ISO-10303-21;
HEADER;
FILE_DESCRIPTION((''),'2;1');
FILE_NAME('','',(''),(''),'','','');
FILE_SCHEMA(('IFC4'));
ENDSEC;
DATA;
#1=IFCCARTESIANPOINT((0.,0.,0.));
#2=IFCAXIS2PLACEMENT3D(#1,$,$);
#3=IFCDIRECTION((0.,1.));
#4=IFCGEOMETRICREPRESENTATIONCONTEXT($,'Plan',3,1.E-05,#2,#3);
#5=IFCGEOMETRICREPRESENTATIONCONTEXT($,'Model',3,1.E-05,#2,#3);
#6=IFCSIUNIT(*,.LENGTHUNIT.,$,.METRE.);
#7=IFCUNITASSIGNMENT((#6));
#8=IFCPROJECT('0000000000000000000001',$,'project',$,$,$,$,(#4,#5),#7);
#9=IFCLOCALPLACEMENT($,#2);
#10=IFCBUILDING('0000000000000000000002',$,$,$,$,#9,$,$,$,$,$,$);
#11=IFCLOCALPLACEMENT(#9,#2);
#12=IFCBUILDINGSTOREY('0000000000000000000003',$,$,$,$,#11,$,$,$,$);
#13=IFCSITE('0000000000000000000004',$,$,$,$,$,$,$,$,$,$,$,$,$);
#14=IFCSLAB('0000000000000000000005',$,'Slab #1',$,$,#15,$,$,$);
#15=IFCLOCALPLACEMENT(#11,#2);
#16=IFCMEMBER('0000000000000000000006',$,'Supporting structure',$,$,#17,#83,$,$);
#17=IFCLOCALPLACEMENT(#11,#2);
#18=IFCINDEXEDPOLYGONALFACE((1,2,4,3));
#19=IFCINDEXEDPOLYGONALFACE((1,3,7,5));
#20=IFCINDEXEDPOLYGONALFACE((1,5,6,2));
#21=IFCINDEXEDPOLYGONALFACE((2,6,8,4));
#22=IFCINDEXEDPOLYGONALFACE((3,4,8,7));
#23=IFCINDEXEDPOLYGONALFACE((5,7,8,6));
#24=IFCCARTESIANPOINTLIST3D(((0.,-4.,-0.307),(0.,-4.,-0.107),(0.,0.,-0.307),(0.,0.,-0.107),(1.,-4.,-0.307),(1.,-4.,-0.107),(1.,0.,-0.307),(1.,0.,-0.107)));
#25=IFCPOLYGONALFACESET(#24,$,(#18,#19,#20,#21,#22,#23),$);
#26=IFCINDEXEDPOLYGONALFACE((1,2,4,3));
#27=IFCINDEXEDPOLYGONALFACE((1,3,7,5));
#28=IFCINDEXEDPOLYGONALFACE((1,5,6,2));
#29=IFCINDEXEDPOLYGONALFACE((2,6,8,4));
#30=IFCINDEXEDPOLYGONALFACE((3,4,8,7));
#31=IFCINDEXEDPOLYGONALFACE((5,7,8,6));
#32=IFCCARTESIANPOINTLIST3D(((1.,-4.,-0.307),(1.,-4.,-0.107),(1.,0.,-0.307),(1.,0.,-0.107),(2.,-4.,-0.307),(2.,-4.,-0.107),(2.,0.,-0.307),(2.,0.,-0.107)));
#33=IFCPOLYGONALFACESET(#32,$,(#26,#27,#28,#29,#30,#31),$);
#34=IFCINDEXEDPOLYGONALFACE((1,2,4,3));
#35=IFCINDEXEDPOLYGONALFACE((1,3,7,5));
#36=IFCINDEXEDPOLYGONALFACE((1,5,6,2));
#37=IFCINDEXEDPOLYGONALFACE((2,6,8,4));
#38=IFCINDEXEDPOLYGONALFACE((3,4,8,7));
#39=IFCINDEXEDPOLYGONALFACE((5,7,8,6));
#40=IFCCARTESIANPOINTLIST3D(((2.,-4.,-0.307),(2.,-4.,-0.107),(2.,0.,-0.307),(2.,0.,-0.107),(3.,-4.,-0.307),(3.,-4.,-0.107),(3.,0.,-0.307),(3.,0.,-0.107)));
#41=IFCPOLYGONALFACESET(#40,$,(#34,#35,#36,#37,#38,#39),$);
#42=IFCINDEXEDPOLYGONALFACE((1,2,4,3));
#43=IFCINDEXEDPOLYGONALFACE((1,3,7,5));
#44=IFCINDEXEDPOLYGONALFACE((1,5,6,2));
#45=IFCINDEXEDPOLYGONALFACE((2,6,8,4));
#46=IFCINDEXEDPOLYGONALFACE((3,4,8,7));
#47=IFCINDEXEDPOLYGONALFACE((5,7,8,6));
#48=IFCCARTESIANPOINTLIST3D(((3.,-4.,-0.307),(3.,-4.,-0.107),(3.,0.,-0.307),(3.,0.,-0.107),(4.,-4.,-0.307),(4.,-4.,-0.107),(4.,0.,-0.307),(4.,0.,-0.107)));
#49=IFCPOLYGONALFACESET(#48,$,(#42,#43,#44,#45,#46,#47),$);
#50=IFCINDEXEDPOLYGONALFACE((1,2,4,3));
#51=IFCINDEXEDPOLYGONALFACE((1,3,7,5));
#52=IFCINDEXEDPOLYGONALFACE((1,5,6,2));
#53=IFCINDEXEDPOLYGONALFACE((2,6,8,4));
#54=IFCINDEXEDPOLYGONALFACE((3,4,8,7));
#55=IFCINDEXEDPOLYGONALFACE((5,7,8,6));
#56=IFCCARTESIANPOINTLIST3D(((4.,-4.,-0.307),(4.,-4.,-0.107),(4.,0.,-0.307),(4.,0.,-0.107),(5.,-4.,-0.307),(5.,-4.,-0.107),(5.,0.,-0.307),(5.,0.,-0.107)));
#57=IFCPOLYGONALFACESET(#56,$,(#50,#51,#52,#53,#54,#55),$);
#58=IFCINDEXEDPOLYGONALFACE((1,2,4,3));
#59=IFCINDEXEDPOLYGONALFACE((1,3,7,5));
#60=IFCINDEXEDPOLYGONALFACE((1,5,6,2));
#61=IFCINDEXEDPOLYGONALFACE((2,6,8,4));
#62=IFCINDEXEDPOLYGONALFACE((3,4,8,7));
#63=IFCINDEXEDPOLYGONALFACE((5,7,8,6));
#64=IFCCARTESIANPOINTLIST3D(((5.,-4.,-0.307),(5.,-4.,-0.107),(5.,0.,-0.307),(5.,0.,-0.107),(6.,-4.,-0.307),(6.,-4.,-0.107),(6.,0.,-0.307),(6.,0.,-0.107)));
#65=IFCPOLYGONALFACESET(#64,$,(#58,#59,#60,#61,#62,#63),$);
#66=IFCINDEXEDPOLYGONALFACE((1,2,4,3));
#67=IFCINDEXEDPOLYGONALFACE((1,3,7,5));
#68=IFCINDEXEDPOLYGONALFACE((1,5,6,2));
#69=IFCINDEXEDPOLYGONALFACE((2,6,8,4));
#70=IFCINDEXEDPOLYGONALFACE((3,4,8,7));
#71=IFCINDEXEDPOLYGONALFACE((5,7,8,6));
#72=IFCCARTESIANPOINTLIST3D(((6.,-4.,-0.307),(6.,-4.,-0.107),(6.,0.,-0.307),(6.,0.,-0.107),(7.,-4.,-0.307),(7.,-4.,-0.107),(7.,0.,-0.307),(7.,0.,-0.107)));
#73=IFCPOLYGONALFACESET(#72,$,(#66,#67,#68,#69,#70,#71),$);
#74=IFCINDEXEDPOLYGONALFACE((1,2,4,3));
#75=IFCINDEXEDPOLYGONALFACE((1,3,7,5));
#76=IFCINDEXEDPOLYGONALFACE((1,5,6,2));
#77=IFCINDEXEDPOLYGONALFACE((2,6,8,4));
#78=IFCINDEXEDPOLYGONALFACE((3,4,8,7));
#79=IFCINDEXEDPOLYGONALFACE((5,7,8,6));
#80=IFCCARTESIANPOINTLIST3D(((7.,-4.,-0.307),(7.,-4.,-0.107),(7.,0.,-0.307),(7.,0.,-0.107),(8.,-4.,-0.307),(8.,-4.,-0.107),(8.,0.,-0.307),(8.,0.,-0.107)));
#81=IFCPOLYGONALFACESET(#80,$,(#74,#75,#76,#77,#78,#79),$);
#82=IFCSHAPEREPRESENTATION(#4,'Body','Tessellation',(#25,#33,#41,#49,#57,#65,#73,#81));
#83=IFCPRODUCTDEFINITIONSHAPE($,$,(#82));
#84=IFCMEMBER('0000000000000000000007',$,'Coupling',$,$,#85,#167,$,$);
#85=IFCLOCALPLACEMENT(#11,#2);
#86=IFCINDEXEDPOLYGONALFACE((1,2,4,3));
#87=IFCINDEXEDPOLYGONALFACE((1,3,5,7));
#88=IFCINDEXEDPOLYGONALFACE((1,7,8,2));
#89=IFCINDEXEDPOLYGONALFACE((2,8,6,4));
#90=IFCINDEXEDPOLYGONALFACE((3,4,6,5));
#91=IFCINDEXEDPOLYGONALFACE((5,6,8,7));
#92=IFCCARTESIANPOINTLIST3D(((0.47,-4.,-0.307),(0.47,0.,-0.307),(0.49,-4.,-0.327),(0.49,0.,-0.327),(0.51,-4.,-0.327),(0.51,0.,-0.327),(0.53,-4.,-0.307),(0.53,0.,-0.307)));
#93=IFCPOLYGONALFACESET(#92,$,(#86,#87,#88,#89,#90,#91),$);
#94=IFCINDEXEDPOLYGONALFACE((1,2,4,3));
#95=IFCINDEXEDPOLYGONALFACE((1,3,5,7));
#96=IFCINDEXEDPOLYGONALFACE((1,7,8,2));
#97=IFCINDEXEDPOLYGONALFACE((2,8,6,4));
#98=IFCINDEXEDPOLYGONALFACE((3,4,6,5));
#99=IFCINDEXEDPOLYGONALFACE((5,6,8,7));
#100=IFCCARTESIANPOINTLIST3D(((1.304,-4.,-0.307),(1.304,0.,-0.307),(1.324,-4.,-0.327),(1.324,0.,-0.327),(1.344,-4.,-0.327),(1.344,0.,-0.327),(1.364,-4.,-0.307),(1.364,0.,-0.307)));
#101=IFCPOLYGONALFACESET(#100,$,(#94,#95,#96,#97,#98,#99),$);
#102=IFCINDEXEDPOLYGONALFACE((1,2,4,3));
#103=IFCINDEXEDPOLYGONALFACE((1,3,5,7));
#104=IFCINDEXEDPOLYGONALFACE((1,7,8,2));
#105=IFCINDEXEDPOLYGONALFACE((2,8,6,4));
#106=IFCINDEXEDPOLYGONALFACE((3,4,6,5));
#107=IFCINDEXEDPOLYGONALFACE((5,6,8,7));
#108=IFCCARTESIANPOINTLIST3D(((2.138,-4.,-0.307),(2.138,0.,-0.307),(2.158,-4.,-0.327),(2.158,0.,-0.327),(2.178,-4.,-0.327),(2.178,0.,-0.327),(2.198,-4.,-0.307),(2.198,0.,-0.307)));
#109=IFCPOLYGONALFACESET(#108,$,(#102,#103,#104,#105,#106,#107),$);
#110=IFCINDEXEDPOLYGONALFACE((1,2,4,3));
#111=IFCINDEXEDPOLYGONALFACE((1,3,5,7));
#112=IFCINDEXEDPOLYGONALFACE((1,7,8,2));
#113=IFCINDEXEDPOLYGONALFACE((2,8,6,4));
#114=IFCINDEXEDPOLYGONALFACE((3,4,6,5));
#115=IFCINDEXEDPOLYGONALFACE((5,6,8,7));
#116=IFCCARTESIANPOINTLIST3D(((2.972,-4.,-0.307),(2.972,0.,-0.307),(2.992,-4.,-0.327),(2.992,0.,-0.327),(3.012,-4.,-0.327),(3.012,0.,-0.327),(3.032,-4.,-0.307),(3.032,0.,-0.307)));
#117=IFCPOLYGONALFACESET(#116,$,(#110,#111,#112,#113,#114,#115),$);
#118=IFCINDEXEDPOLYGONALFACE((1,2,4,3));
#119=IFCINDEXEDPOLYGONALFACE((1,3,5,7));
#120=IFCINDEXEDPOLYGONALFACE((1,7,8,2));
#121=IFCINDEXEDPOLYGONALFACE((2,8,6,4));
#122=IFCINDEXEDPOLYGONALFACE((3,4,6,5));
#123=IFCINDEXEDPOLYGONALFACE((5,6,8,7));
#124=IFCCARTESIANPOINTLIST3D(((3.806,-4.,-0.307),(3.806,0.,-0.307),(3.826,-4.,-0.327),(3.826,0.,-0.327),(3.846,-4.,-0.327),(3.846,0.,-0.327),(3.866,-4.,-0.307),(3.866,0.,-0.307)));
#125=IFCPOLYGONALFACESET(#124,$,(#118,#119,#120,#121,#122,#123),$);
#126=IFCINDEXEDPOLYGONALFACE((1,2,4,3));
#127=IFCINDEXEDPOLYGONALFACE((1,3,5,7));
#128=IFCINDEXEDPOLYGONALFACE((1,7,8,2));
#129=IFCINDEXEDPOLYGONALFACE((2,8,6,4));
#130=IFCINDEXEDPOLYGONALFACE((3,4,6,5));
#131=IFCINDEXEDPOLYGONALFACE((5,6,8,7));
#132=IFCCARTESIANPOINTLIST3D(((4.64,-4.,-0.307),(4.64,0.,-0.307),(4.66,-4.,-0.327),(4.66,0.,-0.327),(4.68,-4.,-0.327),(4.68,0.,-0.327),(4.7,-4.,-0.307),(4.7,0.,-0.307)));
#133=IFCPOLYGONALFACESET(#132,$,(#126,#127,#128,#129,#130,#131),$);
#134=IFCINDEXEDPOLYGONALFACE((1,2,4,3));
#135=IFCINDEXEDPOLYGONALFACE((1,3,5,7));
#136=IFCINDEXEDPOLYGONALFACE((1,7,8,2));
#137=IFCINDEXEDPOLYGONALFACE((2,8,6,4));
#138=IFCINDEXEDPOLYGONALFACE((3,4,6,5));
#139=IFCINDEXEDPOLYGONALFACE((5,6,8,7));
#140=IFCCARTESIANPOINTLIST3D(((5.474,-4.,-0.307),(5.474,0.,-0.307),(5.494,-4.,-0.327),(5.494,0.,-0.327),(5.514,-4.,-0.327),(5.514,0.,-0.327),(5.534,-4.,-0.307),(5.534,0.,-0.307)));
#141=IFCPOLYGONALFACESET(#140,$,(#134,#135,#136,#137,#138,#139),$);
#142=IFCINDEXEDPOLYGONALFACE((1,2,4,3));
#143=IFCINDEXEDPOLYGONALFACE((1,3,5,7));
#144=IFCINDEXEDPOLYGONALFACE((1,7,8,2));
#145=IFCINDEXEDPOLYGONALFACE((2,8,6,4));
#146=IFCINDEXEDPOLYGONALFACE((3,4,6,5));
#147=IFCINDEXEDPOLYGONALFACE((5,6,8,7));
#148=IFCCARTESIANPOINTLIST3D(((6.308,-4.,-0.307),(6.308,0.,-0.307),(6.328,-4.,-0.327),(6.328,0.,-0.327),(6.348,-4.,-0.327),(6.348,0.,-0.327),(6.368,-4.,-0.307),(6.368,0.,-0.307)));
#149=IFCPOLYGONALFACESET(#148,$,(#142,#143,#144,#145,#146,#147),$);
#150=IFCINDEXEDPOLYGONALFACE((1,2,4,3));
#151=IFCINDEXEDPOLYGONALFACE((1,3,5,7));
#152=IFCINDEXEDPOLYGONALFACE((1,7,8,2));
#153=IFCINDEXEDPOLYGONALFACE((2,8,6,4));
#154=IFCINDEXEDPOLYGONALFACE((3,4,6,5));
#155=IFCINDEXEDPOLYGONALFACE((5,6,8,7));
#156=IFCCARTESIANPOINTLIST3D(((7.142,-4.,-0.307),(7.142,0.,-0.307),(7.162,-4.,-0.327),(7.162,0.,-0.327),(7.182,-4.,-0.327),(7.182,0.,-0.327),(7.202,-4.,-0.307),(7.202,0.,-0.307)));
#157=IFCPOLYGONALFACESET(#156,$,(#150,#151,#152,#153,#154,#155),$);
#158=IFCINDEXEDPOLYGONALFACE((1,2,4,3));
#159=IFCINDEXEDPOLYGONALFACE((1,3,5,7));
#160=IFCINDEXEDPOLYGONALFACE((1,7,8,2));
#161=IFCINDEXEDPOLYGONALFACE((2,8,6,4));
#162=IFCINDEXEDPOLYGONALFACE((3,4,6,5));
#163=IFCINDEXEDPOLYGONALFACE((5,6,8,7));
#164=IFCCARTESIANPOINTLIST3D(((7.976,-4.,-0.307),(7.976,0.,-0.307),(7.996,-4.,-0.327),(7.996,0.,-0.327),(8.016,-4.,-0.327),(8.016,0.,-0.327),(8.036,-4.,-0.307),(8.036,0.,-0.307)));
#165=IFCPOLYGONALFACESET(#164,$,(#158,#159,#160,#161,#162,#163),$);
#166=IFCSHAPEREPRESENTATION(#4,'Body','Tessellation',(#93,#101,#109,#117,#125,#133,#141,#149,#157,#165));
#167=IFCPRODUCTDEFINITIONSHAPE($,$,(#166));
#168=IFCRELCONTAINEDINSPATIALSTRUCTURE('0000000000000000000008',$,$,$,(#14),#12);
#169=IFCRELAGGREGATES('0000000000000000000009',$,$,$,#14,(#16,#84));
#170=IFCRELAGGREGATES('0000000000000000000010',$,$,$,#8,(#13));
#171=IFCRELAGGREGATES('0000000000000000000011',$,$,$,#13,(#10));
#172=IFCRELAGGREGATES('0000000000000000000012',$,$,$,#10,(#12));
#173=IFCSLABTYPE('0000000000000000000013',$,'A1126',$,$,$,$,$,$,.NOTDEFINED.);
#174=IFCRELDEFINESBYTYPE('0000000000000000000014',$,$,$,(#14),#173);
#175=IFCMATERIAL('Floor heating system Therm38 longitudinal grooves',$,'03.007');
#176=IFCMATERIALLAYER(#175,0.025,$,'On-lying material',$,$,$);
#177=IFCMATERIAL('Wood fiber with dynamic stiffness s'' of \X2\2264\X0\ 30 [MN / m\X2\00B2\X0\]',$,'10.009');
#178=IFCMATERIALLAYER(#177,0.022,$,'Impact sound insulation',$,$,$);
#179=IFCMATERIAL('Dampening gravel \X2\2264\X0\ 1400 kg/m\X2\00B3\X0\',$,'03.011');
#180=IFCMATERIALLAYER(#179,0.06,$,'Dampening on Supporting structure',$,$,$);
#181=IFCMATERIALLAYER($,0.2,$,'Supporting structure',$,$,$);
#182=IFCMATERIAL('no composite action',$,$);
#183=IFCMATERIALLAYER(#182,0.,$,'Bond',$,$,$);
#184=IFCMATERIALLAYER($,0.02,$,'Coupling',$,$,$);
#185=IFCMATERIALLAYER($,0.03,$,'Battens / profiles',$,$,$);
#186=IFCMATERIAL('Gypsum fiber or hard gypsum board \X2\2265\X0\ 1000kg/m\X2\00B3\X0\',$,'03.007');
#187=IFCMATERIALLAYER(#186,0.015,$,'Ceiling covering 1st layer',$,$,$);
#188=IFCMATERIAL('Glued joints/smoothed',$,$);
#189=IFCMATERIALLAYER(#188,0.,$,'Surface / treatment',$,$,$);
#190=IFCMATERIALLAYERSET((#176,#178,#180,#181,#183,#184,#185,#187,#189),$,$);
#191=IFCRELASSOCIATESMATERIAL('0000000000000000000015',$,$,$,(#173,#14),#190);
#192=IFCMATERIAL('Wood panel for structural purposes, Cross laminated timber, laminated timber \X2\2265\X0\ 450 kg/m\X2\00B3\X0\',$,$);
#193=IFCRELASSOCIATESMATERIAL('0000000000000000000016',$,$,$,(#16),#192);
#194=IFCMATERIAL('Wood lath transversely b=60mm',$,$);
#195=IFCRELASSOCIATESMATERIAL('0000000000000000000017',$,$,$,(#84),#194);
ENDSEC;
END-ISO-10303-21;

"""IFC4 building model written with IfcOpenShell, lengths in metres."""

from ifc_helpers import new_model, si_unit, direction, frame, frame_2d, origin, place, context, project, spatial, polyline, rectangle, outline, extrude, material, layer, layer_set, type_object, element, aggregate, save


model = new_model("IFC4")

# Units and contexts
plan_context = context("Plan", 3, precision=1e-05, world=origin(), true_north=direction((0.0, 1.0)))
model_context = context("Model", 3, precision=1e-05, world=origin(), true_north=direction((0.0, 1.0)))
ifc_project = project(units=[si_unit("LENGTHUNIT", "METRE")], contexts=[plan_context, model_context])

# Site, building, storey
site = spatial("IfcSite", under=ifc_project)
building_placement = place(None, origin())
building = spatial("IfcBuilding", under=site, at=building_placement)
storey_placement = place(building_placement, origin())
storey = spatial("IfcBuildingStorey", under=building, at=storey_placement)

# Slab, members
ifc_material_1 = material(Name="Floor heating system Therm38 longitudinal grooves", Category="03.007")
ifc_layer_1 = layer(ifc_material_1, 0.025, Name="On-lying material")
ifc_material_2 = material(Name="Wood fiber with dynamic stiffness s' of ≤ 30 [MN / m²]", Category="10.009")
ifc_layer_2 = layer(ifc_material_2, 0.022, Name="Impact sound insulation")
ifc_material_3 = material(Name="Dampening gravel ≤ 1400 kg/m³", Category="03.011")
ifc_layer_3 = layer(ifc_material_3, 0.06, Name="Dampening on Supporting structure")
ifc_layer_4 = layer(None, 0.2, Name="Supporting structure")
ifc_material_4 = material(Name="no composite action")
ifc_layer_5 = layer(ifc_material_4, 0.0, Name="Bond")
ifc_layer_6 = layer(None, 0.02, Name="Coupling")
ifc_layer_7 = layer(None, 0.03, Name="Battens / profiles")
ifc_material_5 = material(Name="Gypsum fiber or hard gypsum board ≥ 1000kg/m³", Category="03.007")
ifc_layer_8 = layer(ifc_material_5, 0.015, Name="Ceiling covering 1st layer")
ifc_material_6 = material(Name="Glued joints/smoothed")
ifc_layer_9 = layer(ifc_material_6, 0.0, Name="Surface / treatment")
ifc_layer_set = layer_set([ifc_layer_1, ifc_layer_2, ifc_layer_3, ifc_layer_4, ifc_layer_5, ifc_layer_6, ifc_layer_7, ifc_layer_8, ifc_layer_9])
slab_type = type_object("IfcSlabType", Name="A1126", PredefinedType="NOTDEFINED", material=ifc_layer_set)
slab_placement = place(None, frame((0.0, 0.0, 0.0), z_axis=(0.0, 0.0, -1.0), x_axis=(1.0, 0.0, 0.0)))
slab = element("IfcSlab", 1, at=slab_placement, inside=storey, type_object=slab_type, material=ifc_layer_set, Name="Slab #1")
ifc_material_7 = material(Name="Wood panel for structural purposes, Cross laminated timber, laminated timber ≥ 450 kg/m³")
member_1_placement = place(slab_placement, origin())
member_1 = element("IfcMember", 2, at=member_1_placement, material=ifc_material_7, Name="Supporting structure", context=plan_context, shape_type="SweptSolid", body=[
    extrude(rectangle(XDim=1.0, YDim=0.2, at=frame_2d((0.5, 0.1), x_axis=(1.0, 0.0))), frame((0.0, 4.0, 0.107), z_axis=(0.0, -1.0, 0.0), x_axis=(1.0, 0.0, 0.0)), (0.0, 0.0, 1.0), 4.0),
    extrude(rectangle(XDim=1.0, YDim=0.2, at=frame_2d((0.5, 0.1), x_axis=(1.0, 0.0))), frame((1.0, 4.0, 0.107), z_axis=(0.0, -1.0, 0.0), x_axis=(1.0, 0.0, 0.0)), (0.0, 0.0, 1.0), 4.0),
    extrude(rectangle(XDim=1.0, YDim=0.2, at=frame_2d((0.5, 0.1), x_axis=(1.0, 0.0))), frame((2.0, 4.0, 0.107), z_axis=(0.0, -1.0, 0.0), x_axis=(1.0, 0.0, 0.0)), (0.0, 0.0, 1.0), 4.0),
    extrude(rectangle(XDim=1.0, YDim=0.2, at=frame_2d((0.5, 0.1), x_axis=(1.0, 0.0))), frame((3.0, 4.0, 0.107), z_axis=(0.0, -1.0, 0.0), x_axis=(1.0, 0.0, 0.0)), (0.0, 0.0, 1.0), 4.0),
    extrude(rectangle(XDim=1.0, YDim=0.2, at=frame_2d((0.5, 0.1), x_axis=(1.0, 0.0))), frame((4.0, 4.0, 0.107), z_axis=(0.0, -1.0, 0.0), x_axis=(1.0, 0.0, 0.0)), (0.0, 0.0, 1.0), 4.0),
    extrude(rectangle(XDim=1.0, YDim=0.2, at=frame_2d((0.5, 0.1), x_axis=(1.0, 0.0))), frame((5.0, 4.0, 0.107), z_axis=(0.0, -1.0, 0.0), x_axis=(1.0, 0.0, 0.0)), (0.0, 0.0, 1.0), 4.0),
    extrude(rectangle(XDim=1.0, YDim=0.2, at=frame_2d((0.5, 0.1), x_axis=(1.0, 0.0))), frame((6.0, 4.0, 0.107), z_axis=(0.0, -1.0, 0.0), x_axis=(1.0, 0.0, 0.0)), (0.0, 0.0, 1.0), 4.0),
    extrude(rectangle(XDim=1.0, YDim=0.2, at=frame_2d((0.5, 0.1), x_axis=(1.0, 0.0))), frame((7.0, 4.0, 0.107), z_axis=(0.0, -1.0, 0.0), x_axis=(1.0, 0.0, 0.0)), (0.0, 0.0, 1.0), 4.0),
])
ifc_material_8 = material(Name="Wood lath transversely b=60mm")
member_2_placement = place(slab_placement, origin())
member_2 = element("IfcMember", 3, at=member_2_placement, material=ifc_material_8, Name="Coupling", context=plan_context, shape_type="SweptSolid", body=[
    extrude(outline(polyline([(0.0, 0.0), (0.06, 0.0), (0.04, 0.02), (0.02, 0.02), (0.0, 0.0)])), frame((0.47, 4.0, 0.307), z_axis=(0.0, -1.0, 0.0), x_axis=(1.0, 0.0, 0.0)), (0.0, 0.0, 1.0), 4.0),
    extrude(outline(polyline([(0.0, 0.0), (0.06, 0.0), (0.04, 0.02), (0.02, 0.02), (0.0, 0.0)])), frame((1.304, 4.0, 0.307), z_axis=(0.0, -1.0, 0.0), x_axis=(1.0, 0.0, 0.0)), (0.0, 0.0, 1.0), 4.0),
    extrude(outline(polyline([(0.0, 0.0), (0.06, 0.0), (0.04, 0.02), (0.02, 0.02), (0.0, 0.0)])), frame((2.138, 4.0, 0.307), z_axis=(0.0, -1.0, 0.0), x_axis=(1.0, 0.0, 0.0)), (0.0, 0.0, 1.0), 4.0),
    extrude(outline(polyline([(0.0, 0.0), (0.06, 0.0), (0.04, 0.02), (0.02, 0.02), (0.0, 0.0)])), frame((2.972, 4.0, 0.307), z_axis=(0.0, -1.0, 0.0), x_axis=(1.0, 0.0, 0.0)), (0.0, 0.0, 1.0), 4.0),
    extrude(outline(polyline([(0.0, 0.0), (0.06, 0.0), (0.04, 0.02), (0.02, 0.02), (0.0, 0.0)])), frame((3.806, 4.0, 0.307), z_axis=(0.0, -1.0, 0.0), x_axis=(1.0, 0.0, 0.0)), (0.0, 0.0, 1.0), 4.0),
    extrude(outline(polyline([(0.0, 0.0), (0.06, 0.0), (0.04, 0.02), (0.02, 0.02), (0.0, 0.0)])), frame((4.64, 4.0, 0.307), z_axis=(0.0, -1.0, 0.0), x_axis=(1.0, 0.0, 0.0)), (0.0, 0.0, 1.0), 4.0),
    extrude(outline(polyline([(0.0, 0.0), (0.06, 0.0), (0.04, 0.02), (0.02, 0.02), (0.0, 0.0)])), frame((5.474, 4.0, 0.307), z_axis=(0.0, -1.0, 0.0), x_axis=(1.0, 0.0, 0.0)), (0.0, 0.0, 1.0), 4.0),
    extrude(outline(polyline([(0.0, 0.0), (0.06, 0.0), (0.04, 0.02), (0.02, 0.02), (0.0, 0.0)])), frame((6.308, 4.0, 0.307), z_axis=(0.0, -1.0, 0.0), x_axis=(1.0, 0.0, 0.0)), (0.0, 0.0, 1.0), 4.0),
    extrude(outline(polyline([(0.0, 0.0), (0.06, 0.0), (0.04, 0.02), (0.02, 0.02), (0.0, 0.0)])), frame((7.142, 4.0, 0.307), z_axis=(0.0, -1.0, 0.0), x_axis=(1.0, 0.0, 0.0)), (0.0, 0.0, 1.0), 4.0),
    extrude(outline(polyline([(0.0, 0.0), (0.06, 0.0), (0.04, 0.02), (0.02, 0.02), (0.0, 0.0)])), frame((7.976, 4.0, 0.307), z_axis=(0.0, -1.0, 0.0), x_axis=(1.0, 0.0, 0.0)), (0.0, 0.0, 1.0), 4.0),
])
aggregate(slab, [member_1, member_2])

save(model, "model.ifc")
